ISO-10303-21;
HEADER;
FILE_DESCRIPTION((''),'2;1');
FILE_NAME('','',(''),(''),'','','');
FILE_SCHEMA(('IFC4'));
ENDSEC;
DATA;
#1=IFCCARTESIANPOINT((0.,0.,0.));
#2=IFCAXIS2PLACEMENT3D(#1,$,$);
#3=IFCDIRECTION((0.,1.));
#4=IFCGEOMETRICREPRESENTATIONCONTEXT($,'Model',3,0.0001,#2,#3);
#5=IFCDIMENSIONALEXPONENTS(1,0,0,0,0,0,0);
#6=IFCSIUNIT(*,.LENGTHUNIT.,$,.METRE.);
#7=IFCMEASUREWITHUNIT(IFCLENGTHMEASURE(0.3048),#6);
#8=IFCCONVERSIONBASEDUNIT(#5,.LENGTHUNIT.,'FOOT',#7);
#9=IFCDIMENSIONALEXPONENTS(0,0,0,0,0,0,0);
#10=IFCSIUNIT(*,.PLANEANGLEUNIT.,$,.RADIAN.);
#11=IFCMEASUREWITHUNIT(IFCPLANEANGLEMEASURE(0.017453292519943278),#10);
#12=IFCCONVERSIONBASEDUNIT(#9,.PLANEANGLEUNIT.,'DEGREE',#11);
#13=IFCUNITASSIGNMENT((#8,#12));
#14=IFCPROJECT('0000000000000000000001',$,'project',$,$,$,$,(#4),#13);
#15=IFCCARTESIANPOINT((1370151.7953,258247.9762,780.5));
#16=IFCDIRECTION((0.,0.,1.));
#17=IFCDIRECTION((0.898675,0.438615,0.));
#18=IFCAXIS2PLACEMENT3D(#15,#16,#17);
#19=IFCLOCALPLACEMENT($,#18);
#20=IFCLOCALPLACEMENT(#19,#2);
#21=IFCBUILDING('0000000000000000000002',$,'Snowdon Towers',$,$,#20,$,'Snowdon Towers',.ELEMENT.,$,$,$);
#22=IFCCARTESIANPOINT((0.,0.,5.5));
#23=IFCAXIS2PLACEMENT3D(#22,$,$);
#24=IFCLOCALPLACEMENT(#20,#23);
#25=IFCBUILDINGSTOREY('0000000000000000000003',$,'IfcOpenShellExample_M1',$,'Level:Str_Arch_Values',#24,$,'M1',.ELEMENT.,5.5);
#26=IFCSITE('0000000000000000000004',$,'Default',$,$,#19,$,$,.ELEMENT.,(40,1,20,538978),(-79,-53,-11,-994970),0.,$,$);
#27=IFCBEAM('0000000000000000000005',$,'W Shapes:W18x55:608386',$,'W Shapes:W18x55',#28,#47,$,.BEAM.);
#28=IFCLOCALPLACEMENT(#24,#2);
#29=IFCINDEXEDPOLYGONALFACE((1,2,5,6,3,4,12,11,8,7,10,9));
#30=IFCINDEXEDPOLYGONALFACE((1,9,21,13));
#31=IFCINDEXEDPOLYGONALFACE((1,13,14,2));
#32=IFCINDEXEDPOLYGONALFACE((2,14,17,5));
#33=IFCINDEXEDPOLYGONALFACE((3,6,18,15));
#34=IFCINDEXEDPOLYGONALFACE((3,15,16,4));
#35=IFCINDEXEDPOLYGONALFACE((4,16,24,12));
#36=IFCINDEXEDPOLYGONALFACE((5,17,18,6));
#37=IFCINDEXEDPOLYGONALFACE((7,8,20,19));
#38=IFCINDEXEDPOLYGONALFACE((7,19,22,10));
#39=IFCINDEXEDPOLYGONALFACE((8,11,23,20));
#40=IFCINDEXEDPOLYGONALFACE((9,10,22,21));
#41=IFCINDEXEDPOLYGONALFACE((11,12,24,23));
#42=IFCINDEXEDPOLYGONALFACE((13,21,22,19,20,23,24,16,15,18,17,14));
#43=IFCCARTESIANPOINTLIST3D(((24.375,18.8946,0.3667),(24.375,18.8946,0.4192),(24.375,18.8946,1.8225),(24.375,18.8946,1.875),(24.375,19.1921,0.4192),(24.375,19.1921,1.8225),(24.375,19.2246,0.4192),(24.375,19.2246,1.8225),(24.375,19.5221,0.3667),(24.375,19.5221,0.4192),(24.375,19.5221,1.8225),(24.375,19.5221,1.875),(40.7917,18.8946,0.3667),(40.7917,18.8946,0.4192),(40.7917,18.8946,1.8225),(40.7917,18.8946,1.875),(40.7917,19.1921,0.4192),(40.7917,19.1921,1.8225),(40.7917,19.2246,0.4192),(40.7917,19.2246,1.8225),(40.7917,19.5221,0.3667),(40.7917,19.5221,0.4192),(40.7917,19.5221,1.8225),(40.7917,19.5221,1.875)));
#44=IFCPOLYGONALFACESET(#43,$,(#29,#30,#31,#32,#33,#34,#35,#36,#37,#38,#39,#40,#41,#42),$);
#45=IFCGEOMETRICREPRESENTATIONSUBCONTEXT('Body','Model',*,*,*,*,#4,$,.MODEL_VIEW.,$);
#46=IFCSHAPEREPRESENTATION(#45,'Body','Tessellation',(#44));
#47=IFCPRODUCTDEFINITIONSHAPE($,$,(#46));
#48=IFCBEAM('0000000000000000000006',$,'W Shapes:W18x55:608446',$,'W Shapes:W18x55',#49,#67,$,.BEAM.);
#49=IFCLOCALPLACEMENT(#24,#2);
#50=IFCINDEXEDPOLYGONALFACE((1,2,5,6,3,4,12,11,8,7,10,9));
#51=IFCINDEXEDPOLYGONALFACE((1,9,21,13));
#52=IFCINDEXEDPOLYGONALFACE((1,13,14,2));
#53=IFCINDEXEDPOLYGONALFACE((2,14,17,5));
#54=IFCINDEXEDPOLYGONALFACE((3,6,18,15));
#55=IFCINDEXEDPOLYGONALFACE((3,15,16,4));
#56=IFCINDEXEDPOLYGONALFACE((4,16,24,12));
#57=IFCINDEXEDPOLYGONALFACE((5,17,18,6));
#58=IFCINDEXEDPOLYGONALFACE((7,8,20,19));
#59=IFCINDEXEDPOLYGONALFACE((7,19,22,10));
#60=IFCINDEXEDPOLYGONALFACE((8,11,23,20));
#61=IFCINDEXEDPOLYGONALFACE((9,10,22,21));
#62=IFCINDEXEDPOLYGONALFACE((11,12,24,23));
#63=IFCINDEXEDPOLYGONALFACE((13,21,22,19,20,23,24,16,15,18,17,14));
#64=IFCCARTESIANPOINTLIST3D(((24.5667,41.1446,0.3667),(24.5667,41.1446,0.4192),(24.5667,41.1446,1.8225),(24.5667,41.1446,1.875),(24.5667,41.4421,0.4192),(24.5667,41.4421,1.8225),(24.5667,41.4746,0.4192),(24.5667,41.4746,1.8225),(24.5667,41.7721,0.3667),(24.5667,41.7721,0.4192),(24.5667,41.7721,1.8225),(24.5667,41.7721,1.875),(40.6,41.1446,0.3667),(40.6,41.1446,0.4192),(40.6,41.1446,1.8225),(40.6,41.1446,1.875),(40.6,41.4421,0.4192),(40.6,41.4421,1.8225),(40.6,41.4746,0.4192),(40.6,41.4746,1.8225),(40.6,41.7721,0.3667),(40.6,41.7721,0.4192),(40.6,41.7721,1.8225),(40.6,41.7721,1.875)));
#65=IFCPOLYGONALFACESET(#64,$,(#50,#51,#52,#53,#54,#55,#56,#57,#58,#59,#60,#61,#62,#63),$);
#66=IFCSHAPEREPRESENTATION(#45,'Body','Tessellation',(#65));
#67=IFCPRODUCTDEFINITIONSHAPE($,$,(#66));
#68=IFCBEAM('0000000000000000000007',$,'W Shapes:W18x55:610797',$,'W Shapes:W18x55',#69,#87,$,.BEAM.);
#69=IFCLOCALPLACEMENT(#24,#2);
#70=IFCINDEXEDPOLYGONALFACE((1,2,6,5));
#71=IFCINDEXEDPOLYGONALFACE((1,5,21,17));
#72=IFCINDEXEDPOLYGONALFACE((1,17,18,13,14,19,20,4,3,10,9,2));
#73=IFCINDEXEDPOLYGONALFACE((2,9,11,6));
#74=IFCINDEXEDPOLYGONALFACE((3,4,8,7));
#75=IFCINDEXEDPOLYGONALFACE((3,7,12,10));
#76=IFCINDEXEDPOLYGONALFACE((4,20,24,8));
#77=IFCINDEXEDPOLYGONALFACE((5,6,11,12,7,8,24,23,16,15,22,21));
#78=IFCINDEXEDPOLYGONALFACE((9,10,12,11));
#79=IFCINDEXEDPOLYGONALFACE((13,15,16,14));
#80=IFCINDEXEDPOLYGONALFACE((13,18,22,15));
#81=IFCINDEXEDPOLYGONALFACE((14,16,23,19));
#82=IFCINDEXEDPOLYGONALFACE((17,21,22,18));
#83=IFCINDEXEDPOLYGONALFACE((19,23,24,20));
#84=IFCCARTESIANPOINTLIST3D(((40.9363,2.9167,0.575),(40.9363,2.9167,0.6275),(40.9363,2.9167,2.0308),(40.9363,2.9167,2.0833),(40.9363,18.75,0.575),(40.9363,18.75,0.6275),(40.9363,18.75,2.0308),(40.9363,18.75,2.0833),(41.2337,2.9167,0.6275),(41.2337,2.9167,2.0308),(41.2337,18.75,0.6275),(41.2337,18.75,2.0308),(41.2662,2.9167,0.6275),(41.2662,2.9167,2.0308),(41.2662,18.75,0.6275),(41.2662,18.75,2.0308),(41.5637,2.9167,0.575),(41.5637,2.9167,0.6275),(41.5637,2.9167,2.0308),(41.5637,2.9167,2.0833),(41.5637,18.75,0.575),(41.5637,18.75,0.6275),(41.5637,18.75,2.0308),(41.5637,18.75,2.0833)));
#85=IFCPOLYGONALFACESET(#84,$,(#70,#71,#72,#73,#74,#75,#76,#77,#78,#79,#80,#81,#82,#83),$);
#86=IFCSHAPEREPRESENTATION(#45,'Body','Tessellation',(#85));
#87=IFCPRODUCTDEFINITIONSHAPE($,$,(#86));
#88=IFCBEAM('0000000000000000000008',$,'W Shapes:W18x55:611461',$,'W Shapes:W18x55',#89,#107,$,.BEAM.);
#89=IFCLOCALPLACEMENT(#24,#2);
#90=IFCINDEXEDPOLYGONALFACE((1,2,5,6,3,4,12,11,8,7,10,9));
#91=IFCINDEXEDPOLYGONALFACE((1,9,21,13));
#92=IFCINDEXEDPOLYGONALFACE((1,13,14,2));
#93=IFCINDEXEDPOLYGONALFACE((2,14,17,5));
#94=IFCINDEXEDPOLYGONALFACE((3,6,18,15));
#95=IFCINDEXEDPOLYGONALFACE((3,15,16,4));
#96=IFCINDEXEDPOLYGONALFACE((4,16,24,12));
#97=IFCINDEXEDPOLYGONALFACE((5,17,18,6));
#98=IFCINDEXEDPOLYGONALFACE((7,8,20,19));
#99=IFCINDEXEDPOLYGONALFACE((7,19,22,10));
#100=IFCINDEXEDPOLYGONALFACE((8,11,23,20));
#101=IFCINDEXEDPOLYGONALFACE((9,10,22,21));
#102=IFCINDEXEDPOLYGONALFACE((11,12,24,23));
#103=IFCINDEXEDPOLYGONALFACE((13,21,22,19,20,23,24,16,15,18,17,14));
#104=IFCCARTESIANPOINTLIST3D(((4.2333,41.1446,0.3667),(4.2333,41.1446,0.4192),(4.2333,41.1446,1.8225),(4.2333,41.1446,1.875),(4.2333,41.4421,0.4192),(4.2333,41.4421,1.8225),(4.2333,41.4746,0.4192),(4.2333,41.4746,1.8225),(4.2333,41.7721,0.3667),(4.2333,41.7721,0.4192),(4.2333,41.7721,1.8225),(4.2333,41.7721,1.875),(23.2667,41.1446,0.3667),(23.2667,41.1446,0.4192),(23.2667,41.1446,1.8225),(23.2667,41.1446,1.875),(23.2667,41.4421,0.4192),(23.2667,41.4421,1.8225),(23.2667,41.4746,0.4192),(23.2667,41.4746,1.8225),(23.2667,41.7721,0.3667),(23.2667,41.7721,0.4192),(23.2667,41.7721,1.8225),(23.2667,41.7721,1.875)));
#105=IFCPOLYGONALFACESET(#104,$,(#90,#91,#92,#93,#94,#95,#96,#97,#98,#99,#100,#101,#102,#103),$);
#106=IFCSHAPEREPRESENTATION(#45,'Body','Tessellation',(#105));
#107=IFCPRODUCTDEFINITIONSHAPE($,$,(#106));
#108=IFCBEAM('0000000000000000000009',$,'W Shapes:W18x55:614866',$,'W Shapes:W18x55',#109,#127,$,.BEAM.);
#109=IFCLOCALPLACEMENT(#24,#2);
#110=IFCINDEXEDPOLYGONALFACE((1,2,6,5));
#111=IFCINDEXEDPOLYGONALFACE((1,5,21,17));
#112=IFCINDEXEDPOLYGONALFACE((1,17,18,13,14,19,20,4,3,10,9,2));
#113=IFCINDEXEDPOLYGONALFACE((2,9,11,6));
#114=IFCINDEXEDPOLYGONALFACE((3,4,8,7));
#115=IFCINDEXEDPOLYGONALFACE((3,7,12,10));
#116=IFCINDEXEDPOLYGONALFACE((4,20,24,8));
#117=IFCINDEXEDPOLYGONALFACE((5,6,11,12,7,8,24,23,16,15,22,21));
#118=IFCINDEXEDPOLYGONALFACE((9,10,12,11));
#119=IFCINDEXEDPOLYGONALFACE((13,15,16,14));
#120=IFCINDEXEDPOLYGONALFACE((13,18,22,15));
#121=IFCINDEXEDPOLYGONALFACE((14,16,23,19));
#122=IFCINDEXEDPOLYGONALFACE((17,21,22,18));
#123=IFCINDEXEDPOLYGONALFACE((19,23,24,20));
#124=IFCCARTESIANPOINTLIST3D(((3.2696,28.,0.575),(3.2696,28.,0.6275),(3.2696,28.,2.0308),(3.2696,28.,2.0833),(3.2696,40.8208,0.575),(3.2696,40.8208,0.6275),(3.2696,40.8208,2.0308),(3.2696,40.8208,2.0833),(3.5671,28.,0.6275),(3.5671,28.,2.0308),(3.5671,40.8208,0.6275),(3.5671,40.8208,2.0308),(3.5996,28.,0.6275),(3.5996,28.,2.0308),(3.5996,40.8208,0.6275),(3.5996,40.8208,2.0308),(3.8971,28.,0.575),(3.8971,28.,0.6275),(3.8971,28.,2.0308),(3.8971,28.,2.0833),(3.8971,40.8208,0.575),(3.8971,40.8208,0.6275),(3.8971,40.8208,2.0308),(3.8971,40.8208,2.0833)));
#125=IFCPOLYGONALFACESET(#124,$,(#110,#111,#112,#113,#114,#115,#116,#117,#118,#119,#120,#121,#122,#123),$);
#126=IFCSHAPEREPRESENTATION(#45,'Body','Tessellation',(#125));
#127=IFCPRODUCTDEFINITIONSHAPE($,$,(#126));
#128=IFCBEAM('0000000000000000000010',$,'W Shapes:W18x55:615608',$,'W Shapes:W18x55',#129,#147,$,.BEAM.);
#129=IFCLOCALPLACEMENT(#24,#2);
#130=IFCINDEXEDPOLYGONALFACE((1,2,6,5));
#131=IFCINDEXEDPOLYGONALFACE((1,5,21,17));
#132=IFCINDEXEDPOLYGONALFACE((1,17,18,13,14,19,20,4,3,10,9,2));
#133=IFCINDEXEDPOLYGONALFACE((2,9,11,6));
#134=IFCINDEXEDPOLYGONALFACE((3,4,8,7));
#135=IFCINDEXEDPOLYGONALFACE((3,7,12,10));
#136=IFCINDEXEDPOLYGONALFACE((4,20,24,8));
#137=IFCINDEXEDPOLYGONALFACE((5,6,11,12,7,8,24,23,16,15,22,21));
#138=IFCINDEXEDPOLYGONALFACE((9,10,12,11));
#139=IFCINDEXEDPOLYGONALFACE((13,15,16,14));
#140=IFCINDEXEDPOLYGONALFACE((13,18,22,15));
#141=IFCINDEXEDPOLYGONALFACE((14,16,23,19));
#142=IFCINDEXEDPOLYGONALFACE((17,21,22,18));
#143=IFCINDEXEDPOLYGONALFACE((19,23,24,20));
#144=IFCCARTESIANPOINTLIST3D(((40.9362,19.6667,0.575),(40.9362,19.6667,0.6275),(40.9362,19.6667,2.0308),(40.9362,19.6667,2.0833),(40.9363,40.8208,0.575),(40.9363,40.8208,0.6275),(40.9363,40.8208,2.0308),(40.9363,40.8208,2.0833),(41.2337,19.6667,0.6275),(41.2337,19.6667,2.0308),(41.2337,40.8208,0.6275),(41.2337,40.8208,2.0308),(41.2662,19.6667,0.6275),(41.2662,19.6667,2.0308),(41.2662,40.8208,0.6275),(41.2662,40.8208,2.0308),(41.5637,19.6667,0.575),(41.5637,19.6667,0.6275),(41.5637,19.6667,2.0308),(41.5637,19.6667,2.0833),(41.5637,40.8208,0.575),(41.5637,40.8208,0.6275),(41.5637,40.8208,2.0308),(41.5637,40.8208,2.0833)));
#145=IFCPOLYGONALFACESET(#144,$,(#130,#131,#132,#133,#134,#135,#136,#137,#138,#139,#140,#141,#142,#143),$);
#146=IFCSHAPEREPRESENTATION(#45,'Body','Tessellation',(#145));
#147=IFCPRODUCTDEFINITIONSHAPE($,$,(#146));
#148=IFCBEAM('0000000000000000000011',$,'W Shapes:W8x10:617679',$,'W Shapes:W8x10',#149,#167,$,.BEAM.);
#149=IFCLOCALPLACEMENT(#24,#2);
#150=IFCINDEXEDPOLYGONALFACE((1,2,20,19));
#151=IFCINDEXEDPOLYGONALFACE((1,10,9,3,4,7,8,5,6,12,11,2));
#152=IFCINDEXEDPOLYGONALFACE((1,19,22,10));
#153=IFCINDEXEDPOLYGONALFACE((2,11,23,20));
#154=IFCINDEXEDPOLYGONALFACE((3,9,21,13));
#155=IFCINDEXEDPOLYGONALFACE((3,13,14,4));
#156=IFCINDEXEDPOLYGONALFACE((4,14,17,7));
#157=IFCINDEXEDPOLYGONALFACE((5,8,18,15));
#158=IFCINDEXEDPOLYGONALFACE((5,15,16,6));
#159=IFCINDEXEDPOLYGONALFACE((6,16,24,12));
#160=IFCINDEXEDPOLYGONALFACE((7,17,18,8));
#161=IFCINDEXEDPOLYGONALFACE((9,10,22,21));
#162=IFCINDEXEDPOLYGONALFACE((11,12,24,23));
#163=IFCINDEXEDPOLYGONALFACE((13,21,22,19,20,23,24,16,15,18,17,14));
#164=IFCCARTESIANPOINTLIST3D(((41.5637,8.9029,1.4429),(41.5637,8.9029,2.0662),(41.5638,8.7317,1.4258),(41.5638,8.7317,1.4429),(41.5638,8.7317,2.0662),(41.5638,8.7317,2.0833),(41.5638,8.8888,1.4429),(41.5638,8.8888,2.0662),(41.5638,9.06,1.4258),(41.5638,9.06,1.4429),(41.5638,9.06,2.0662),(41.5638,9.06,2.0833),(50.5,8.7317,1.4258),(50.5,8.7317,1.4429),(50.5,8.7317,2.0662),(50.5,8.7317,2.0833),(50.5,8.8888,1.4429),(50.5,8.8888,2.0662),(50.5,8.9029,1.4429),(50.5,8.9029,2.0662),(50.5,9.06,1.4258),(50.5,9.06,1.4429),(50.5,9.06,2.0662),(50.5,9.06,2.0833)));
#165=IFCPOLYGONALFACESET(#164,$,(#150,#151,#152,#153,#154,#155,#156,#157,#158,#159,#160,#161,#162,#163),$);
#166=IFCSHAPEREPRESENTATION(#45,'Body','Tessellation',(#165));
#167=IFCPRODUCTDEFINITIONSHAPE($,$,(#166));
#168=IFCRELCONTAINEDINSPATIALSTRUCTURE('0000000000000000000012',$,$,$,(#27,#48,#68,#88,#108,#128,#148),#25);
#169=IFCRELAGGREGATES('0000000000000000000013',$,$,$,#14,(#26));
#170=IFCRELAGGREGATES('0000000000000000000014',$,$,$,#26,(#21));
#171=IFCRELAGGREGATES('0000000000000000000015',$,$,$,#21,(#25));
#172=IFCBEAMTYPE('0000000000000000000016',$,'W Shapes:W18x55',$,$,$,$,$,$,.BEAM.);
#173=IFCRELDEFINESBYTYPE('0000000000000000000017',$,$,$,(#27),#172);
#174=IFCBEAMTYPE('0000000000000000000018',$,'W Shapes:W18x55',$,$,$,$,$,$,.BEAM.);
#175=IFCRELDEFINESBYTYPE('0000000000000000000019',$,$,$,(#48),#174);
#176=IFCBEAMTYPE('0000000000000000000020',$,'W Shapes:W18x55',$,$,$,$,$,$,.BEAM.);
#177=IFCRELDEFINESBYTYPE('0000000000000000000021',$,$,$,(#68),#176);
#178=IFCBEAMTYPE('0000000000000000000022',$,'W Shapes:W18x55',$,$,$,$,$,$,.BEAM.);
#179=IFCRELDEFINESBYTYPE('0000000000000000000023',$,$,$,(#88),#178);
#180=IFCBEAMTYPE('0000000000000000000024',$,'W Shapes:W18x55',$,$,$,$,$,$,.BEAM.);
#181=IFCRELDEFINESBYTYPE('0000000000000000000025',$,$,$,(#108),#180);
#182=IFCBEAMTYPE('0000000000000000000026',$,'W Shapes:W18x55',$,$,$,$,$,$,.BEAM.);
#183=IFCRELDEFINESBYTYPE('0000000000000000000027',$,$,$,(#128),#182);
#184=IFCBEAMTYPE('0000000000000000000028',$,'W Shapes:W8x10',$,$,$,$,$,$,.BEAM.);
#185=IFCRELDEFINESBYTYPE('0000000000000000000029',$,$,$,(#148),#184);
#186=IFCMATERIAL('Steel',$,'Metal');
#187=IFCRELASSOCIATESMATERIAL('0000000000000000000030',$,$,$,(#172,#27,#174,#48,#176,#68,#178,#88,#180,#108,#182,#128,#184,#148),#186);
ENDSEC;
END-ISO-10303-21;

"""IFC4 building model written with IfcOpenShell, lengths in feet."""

from ifc_helpers import new_model, entity, si_unit, converted_unit, direction, frame, origin, place, context, subcontext, project, spatial, indexed_curve, outline, extrude, source, transform, mapped, material, type_object, type_shapes, element, save


model = new_model("IFC4")

# Units and contexts
model_context = context("Model", 3, precision=0.0001, world=origin(), true_north=direction((0.0, 1.0)))
body_context = subcontext(model_context, "Body", "Model", "MODEL_VIEW")
ifc_project = project(units=[converted_unit("LENGTHUNIT", "FOOT", entity("IfcLengthMeasure", 0.3048), si_unit("LENGTHUNIT", "METRE"), dimensions=[1, 0, 0, 0, 0, 0, 0]), converted_unit("PLANEANGLEUNIT", "DEGREE", entity("IfcPlaneAngleMeasure", 0.017453292519943278), si_unit("PLANEANGLEUNIT", "RADIAN"), dimensions=[0, 0, 0, 0, 0, 0, 0])], contexts=[model_context])

# Site, building, storey
site_placement = place(None, frame((1370151.7953, 258247.9762, 780.5), z_axis=(0.0, 0.0, 1.0), x_axis=(0.898675, 0.438615, 0.0)))
site = spatial("IfcSite", under=ifc_project, at=site_placement, Name="Default", CompositionType="ELEMENT", RefLatitude=(40, 1, 20, 538978), RefLongitude=(-79, -53, -11, -994970), RefElevation=0.0)
building_placement = place(site_placement, origin())
building = spatial("IfcBuilding", under=site, at=building_placement, Name="Snowdon Towers", LongName="Snowdon Towers", CompositionType="ELEMENT")
storey_placement = place(building_placement, frame((0.0, 0.0, 5.5)))
storey = spatial("IfcBuildingStorey", under=building, at=storey_placement, Name="IfcOpenShellExample_M1", ObjectType="Level:Str_Arch_Values", LongName="M1", CompositionType="ELEMENT", Elevation=5.5)

# Beams
ifc_material = material(Name="Steel", Category="Metal")
beam_type_1 = type_object("IfcBeamType", Name="W Shapes:W18x55", PredefinedType="BEAM", material=ifc_material)
shared_shape_1 = source(origin(), body_context, "Body", "SweptSolid", [
    extrude(outline(indexed_curve([(-0.3138, -0.7017), (-0.3138, -0.7542), (0.3138, -0.7542), (0.3138, -0.7017), (0.0162, -0.7017), (0.0162, 0.7017), (0.3138, 0.7017), (0.3138, 0.7542), (-0.3137, 0.7542), (-0.3137, 0.7017), (-0.0163, 0.7017), (-0.0163, -0.7017), (-0.3138, -0.7017)], self_intersect=False)), frame((-8.2083, 0.0, 0.0), z_axis=(-1.0, 0.0, 0.0), x_axis=(0.0, -1.0, 0.0)), (0.0, 0.0, -1.0), 16.4167),
])
type_shapes(beam_type_1, [shared_shape_1])
beam_1_placement = place(storey_placement, frame((32.5833, 19.2083, 1.1208)))
element("IfcBeam", 1, at=beam_1_placement, inside=storey, type_object=beam_type_1, material=ifc_material, Name="W Shapes:W18x55:608386", ObjectType="W Shapes:W18x55", PredefinedType="BEAM", context=body_context, shape_type="MappedRepresentation", body=[
    mapped(shared_shape_1, transform((0.0, 0.0, 0.0), scale=1.0)),
])
beam_type_2 = type_object("IfcBeamType", Name="W Shapes:W18x55", PredefinedType="BEAM", material=ifc_material)
shared_shape_2 = source(origin(), body_context, "Body", "SweptSolid", [
    extrude(outline(indexed_curve([(-0.3138, -0.7017), (-0.3138, -0.7542), (0.3138, -0.7542), (0.3138, -0.7017), (0.0162, -0.7017), (0.0162, 0.7017), (0.3138, 0.7017), (0.3138, 0.7542), (-0.3137, 0.7542), (-0.3137, 0.7017), (-0.0163, 0.7017), (-0.0163, -0.7017), (-0.3138, -0.7017)], self_intersect=False)), frame((-8.0167, 0.0, 0.0), z_axis=(-1.0, 0.0, 0.0), x_axis=(0.0, -1.0, 0.0)), (0.0, 0.0, -1.0), 16.0333),
])
type_shapes(beam_type_2, [shared_shape_2])
beam_2_placement = place(storey_placement, frame((32.5833, 41.4583, 1.1208)))
element("IfcBeam", 2, at=beam_2_placement, inside=storey, type_object=beam_type_2, material=ifc_material, Name="W Shapes:W18x55:608446", ObjectType="W Shapes:W18x55", PredefinedType="BEAM", context=body_context, shape_type="MappedRepresentation", body=[
    mapped(shared_shape_2, transform((0.0, 0.0, 0.0), scale=1.0)),
])

# Beams
beam_type_3 = type_object("IfcBeamType", Name="W Shapes:W18x55", PredefinedType="BEAM", material=ifc_material)
shared_shape_3 = source(origin(), body_context, "Body", "SweptSolid", [
    extrude(outline(indexed_curve([(-0.3138, -0.7017), (-0.3138, -0.7542), (0.3138, -0.7542), (0.3138, -0.7017), (0.0162, -0.7017), (0.0162, 0.7017), (0.3138, 0.7017), (0.3138, 0.7542), (-0.3137, 0.7542), (-0.3137, 0.7017), (-0.0163, 0.7017), (-0.0163, -0.7017), (-0.3138, -0.7017)], self_intersect=False)), frame((-7.875, 0.0, 0.0), z_axis=(-1.0, 0.0, 0.0), x_axis=(0.0, -1.0, 0.0)), (0.0, 0.0, -1.0), 15.8333),
])
type_shapes(beam_type_3, [shared_shape_3])
beam_3_placement = place(storey_placement, frame((41.25, 10.7917, 1.3292), z_axis=(0.0, 0.0, 1.0), x_axis=(0.0, 1.0, 0.0)))
element("IfcBeam", 3, at=beam_3_placement, inside=storey, type_object=beam_type_3, material=ifc_material, Name="W Shapes:W18x55:610797", ObjectType="W Shapes:W18x55", PredefinedType="BEAM", context=body_context, shape_type="MappedRepresentation", body=[
    mapped(shared_shape_3, transform((0.0, 0.0, 0.0), scale=1.0)),
])
beam_type_4 = type_object("IfcBeamType", Name="W Shapes:W18x55", PredefinedType="BEAM", material=ifc_material)
shared_shape_4 = source(origin(), body_context, "Body", "SweptSolid", [
    extrude(outline(indexed_curve([(-0.3138, -0.7017), (-0.3138, -0.7542), (0.3138, -0.7542), (0.3138, -0.7017), (0.0162, -0.7017), (0.0162, 0.7017), (0.3138, 0.7017), (0.3138, 0.7542), (-0.3137, 0.7542), (-0.3137, 0.7017), (-0.0163, 0.7017), (-0.0163, -0.7017), (-0.3138, -0.7017)], self_intersect=False)), frame((-9.6, 0.0, 0.0), z_axis=(-1.0, 0.0, 0.0), x_axis=(0.0, -1.0, 0.0)), (0.0, 0.0, -1.0), 19.0333),
])
type_shapes(beam_type_4, [shared_shape_4])
beam_4_placement = place(storey_placement, frame((13.8333, 41.4583, 1.1208)))
element("IfcBeam", 4, at=beam_4_placement, inside=storey, type_object=beam_type_4, material=ifc_material, Name="W Shapes:W18x55:611461", ObjectType="W Shapes:W18x55", PredefinedType="BEAM", context=body_context, shape_type="MappedRepresentation", body=[
    mapped(shared_shape_4, transform((0.0, 0.0, 0.0), scale=1.0)),
])
beam_type_5 = type_object("IfcBeamType", Name="W Shapes:W18x55", PredefinedType="BEAM", material=ifc_material)
shared_shape_5 = source(origin(), body_context, "Body", "SweptSolid", [
    extrude(outline(indexed_curve([(-0.3138, -0.7017), (-0.3138, -0.7542), (0.3138, -0.7542), (0.3138, -0.7017), (0.0162, -0.7017), (0.0162, 0.7017), (0.3138, 0.7017), (0.3138, 0.7542), (-0.3137, 0.7542), (-0.3137, 0.7017), (-0.0163, 0.7017), (-0.0163, -0.7017), (-0.3138, -0.7017)], self_intersect=False)), frame((-6.5833, 0.0, 0.0), z_axis=(-1.0, 0.0, 0.0), x_axis=(0.0, -1.0, 0.0)), (0.0, 0.0, -1.0), 12.8208),
])
type_shapes(beam_type_5, [shared_shape_5])
beam_5_placement = place(storey_placement, frame((3.5833, 34.5833, 1.3292), z_axis=(0.0, 0.0, 1.0), x_axis=(0.0, 1.0, 0.0)))
element("IfcBeam", 5, at=beam_5_placement, inside=storey, type_object=beam_type_5, material=ifc_material, Name="W Shapes:W18x55:614866", ObjectType="W Shapes:W18x55", PredefinedType="BEAM", context=body_context, shape_type="MappedRepresentation", body=[
    mapped(shared_shape_5, transform((0.0, 0.0, 0.0), scale=1.0)),
])
beam_type_6 = type_object("IfcBeamType", Name="W Shapes:W18x55", PredefinedType="BEAM", material=ifc_material)
shared_shape_6 = source(origin(), body_context, "Body", "SweptSolid", [
    extrude(outline(indexed_curve([(-0.3138, -0.7017), (-0.3138, -0.7542), (0.3138, -0.7542), (0.3138, -0.7017), (0.0162, -0.7017), (0.0162, 0.7017), (0.3138, 0.7017), (0.3138, 0.7542), (-0.3137, 0.7542), (-0.3137, 0.7017), (-0.0163, 0.7017), (-0.0163, -0.7017), (-0.3138, -0.7017)], self_intersect=False)), frame((-10.75, 0.0, 0.0), z_axis=(-1.0, 0.0, 0.0), x_axis=(0.0, -1.0, 0.0)), (0.0, 0.0, -1.0), 21.1542),
])
type_shapes(beam_type_6, [shared_shape_6])
beam_6_placement = place(storey_placement, frame((41.25, 30.4167, 1.3292), z_axis=(0.0, 0.0, 1.0), x_axis=(0.0, 1.0, 0.0)))
element("IfcBeam", 6, at=beam_6_placement, inside=storey, type_object=beam_type_6, material=ifc_material, Name="W Shapes:W18x55:615608", ObjectType="W Shapes:W18x55", PredefinedType="BEAM", context=body_context, shape_type="MappedRepresentation", body=[
    mapped(shared_shape_6, transform((0.0, 0.0, 0.0), scale=1.0)),
])
beam_type_7 = type_object("IfcBeamType", Name="W Shapes:W8x10", PredefinedType="BEAM", material=ifc_material)
shared_shape_7 = source(origin(), body_context, "Body", "SweptSolid", [
    extrude(outline(indexed_curve([(-0.1642, -0.3117), (-0.1642, -0.3288), (0.1642, -0.3288), (0.1642, -0.3117), (0.0071, -0.3117), (0.0071, 0.3117), (0.1642, 0.3117), (0.1642, 0.3287), (-0.1642, 0.3287), (-0.1642, 0.3117), (-0.0071, 0.3117), (-0.0071, -0.3117), (-0.1642, -0.3117)], self_intersect=False)), frame((-4.4792, 0.0, 0.0), z_axis=(-1.0, 0.0, 0.0), x_axis=(0.0, -1.0, 0.0)), (0.0, 0.0, -1.0), 8.9362),
])
type_shapes(beam_type_7, [shared_shape_7])
beam_7_placement = place(storey_placement, frame((46.0208, 8.8958, 1.7546), z_axis=(0.0, 0.0, 1.0), x_axis=(-1.0, 0.0, 0.0)))
element("IfcBeam", 7, at=beam_7_placement, inside=storey, type_object=beam_type_7, material=ifc_material, Name="W Shapes:W8x10:617679", ObjectType="W Shapes:W8x10", PredefinedType="BEAM", context=body_context, shape_type="MappedRepresentation", body=[
    mapped(shared_shape_7, transform((0.0, 0.0, 0.0), scale=1.0)),
])

save(model, "model.ifc")
